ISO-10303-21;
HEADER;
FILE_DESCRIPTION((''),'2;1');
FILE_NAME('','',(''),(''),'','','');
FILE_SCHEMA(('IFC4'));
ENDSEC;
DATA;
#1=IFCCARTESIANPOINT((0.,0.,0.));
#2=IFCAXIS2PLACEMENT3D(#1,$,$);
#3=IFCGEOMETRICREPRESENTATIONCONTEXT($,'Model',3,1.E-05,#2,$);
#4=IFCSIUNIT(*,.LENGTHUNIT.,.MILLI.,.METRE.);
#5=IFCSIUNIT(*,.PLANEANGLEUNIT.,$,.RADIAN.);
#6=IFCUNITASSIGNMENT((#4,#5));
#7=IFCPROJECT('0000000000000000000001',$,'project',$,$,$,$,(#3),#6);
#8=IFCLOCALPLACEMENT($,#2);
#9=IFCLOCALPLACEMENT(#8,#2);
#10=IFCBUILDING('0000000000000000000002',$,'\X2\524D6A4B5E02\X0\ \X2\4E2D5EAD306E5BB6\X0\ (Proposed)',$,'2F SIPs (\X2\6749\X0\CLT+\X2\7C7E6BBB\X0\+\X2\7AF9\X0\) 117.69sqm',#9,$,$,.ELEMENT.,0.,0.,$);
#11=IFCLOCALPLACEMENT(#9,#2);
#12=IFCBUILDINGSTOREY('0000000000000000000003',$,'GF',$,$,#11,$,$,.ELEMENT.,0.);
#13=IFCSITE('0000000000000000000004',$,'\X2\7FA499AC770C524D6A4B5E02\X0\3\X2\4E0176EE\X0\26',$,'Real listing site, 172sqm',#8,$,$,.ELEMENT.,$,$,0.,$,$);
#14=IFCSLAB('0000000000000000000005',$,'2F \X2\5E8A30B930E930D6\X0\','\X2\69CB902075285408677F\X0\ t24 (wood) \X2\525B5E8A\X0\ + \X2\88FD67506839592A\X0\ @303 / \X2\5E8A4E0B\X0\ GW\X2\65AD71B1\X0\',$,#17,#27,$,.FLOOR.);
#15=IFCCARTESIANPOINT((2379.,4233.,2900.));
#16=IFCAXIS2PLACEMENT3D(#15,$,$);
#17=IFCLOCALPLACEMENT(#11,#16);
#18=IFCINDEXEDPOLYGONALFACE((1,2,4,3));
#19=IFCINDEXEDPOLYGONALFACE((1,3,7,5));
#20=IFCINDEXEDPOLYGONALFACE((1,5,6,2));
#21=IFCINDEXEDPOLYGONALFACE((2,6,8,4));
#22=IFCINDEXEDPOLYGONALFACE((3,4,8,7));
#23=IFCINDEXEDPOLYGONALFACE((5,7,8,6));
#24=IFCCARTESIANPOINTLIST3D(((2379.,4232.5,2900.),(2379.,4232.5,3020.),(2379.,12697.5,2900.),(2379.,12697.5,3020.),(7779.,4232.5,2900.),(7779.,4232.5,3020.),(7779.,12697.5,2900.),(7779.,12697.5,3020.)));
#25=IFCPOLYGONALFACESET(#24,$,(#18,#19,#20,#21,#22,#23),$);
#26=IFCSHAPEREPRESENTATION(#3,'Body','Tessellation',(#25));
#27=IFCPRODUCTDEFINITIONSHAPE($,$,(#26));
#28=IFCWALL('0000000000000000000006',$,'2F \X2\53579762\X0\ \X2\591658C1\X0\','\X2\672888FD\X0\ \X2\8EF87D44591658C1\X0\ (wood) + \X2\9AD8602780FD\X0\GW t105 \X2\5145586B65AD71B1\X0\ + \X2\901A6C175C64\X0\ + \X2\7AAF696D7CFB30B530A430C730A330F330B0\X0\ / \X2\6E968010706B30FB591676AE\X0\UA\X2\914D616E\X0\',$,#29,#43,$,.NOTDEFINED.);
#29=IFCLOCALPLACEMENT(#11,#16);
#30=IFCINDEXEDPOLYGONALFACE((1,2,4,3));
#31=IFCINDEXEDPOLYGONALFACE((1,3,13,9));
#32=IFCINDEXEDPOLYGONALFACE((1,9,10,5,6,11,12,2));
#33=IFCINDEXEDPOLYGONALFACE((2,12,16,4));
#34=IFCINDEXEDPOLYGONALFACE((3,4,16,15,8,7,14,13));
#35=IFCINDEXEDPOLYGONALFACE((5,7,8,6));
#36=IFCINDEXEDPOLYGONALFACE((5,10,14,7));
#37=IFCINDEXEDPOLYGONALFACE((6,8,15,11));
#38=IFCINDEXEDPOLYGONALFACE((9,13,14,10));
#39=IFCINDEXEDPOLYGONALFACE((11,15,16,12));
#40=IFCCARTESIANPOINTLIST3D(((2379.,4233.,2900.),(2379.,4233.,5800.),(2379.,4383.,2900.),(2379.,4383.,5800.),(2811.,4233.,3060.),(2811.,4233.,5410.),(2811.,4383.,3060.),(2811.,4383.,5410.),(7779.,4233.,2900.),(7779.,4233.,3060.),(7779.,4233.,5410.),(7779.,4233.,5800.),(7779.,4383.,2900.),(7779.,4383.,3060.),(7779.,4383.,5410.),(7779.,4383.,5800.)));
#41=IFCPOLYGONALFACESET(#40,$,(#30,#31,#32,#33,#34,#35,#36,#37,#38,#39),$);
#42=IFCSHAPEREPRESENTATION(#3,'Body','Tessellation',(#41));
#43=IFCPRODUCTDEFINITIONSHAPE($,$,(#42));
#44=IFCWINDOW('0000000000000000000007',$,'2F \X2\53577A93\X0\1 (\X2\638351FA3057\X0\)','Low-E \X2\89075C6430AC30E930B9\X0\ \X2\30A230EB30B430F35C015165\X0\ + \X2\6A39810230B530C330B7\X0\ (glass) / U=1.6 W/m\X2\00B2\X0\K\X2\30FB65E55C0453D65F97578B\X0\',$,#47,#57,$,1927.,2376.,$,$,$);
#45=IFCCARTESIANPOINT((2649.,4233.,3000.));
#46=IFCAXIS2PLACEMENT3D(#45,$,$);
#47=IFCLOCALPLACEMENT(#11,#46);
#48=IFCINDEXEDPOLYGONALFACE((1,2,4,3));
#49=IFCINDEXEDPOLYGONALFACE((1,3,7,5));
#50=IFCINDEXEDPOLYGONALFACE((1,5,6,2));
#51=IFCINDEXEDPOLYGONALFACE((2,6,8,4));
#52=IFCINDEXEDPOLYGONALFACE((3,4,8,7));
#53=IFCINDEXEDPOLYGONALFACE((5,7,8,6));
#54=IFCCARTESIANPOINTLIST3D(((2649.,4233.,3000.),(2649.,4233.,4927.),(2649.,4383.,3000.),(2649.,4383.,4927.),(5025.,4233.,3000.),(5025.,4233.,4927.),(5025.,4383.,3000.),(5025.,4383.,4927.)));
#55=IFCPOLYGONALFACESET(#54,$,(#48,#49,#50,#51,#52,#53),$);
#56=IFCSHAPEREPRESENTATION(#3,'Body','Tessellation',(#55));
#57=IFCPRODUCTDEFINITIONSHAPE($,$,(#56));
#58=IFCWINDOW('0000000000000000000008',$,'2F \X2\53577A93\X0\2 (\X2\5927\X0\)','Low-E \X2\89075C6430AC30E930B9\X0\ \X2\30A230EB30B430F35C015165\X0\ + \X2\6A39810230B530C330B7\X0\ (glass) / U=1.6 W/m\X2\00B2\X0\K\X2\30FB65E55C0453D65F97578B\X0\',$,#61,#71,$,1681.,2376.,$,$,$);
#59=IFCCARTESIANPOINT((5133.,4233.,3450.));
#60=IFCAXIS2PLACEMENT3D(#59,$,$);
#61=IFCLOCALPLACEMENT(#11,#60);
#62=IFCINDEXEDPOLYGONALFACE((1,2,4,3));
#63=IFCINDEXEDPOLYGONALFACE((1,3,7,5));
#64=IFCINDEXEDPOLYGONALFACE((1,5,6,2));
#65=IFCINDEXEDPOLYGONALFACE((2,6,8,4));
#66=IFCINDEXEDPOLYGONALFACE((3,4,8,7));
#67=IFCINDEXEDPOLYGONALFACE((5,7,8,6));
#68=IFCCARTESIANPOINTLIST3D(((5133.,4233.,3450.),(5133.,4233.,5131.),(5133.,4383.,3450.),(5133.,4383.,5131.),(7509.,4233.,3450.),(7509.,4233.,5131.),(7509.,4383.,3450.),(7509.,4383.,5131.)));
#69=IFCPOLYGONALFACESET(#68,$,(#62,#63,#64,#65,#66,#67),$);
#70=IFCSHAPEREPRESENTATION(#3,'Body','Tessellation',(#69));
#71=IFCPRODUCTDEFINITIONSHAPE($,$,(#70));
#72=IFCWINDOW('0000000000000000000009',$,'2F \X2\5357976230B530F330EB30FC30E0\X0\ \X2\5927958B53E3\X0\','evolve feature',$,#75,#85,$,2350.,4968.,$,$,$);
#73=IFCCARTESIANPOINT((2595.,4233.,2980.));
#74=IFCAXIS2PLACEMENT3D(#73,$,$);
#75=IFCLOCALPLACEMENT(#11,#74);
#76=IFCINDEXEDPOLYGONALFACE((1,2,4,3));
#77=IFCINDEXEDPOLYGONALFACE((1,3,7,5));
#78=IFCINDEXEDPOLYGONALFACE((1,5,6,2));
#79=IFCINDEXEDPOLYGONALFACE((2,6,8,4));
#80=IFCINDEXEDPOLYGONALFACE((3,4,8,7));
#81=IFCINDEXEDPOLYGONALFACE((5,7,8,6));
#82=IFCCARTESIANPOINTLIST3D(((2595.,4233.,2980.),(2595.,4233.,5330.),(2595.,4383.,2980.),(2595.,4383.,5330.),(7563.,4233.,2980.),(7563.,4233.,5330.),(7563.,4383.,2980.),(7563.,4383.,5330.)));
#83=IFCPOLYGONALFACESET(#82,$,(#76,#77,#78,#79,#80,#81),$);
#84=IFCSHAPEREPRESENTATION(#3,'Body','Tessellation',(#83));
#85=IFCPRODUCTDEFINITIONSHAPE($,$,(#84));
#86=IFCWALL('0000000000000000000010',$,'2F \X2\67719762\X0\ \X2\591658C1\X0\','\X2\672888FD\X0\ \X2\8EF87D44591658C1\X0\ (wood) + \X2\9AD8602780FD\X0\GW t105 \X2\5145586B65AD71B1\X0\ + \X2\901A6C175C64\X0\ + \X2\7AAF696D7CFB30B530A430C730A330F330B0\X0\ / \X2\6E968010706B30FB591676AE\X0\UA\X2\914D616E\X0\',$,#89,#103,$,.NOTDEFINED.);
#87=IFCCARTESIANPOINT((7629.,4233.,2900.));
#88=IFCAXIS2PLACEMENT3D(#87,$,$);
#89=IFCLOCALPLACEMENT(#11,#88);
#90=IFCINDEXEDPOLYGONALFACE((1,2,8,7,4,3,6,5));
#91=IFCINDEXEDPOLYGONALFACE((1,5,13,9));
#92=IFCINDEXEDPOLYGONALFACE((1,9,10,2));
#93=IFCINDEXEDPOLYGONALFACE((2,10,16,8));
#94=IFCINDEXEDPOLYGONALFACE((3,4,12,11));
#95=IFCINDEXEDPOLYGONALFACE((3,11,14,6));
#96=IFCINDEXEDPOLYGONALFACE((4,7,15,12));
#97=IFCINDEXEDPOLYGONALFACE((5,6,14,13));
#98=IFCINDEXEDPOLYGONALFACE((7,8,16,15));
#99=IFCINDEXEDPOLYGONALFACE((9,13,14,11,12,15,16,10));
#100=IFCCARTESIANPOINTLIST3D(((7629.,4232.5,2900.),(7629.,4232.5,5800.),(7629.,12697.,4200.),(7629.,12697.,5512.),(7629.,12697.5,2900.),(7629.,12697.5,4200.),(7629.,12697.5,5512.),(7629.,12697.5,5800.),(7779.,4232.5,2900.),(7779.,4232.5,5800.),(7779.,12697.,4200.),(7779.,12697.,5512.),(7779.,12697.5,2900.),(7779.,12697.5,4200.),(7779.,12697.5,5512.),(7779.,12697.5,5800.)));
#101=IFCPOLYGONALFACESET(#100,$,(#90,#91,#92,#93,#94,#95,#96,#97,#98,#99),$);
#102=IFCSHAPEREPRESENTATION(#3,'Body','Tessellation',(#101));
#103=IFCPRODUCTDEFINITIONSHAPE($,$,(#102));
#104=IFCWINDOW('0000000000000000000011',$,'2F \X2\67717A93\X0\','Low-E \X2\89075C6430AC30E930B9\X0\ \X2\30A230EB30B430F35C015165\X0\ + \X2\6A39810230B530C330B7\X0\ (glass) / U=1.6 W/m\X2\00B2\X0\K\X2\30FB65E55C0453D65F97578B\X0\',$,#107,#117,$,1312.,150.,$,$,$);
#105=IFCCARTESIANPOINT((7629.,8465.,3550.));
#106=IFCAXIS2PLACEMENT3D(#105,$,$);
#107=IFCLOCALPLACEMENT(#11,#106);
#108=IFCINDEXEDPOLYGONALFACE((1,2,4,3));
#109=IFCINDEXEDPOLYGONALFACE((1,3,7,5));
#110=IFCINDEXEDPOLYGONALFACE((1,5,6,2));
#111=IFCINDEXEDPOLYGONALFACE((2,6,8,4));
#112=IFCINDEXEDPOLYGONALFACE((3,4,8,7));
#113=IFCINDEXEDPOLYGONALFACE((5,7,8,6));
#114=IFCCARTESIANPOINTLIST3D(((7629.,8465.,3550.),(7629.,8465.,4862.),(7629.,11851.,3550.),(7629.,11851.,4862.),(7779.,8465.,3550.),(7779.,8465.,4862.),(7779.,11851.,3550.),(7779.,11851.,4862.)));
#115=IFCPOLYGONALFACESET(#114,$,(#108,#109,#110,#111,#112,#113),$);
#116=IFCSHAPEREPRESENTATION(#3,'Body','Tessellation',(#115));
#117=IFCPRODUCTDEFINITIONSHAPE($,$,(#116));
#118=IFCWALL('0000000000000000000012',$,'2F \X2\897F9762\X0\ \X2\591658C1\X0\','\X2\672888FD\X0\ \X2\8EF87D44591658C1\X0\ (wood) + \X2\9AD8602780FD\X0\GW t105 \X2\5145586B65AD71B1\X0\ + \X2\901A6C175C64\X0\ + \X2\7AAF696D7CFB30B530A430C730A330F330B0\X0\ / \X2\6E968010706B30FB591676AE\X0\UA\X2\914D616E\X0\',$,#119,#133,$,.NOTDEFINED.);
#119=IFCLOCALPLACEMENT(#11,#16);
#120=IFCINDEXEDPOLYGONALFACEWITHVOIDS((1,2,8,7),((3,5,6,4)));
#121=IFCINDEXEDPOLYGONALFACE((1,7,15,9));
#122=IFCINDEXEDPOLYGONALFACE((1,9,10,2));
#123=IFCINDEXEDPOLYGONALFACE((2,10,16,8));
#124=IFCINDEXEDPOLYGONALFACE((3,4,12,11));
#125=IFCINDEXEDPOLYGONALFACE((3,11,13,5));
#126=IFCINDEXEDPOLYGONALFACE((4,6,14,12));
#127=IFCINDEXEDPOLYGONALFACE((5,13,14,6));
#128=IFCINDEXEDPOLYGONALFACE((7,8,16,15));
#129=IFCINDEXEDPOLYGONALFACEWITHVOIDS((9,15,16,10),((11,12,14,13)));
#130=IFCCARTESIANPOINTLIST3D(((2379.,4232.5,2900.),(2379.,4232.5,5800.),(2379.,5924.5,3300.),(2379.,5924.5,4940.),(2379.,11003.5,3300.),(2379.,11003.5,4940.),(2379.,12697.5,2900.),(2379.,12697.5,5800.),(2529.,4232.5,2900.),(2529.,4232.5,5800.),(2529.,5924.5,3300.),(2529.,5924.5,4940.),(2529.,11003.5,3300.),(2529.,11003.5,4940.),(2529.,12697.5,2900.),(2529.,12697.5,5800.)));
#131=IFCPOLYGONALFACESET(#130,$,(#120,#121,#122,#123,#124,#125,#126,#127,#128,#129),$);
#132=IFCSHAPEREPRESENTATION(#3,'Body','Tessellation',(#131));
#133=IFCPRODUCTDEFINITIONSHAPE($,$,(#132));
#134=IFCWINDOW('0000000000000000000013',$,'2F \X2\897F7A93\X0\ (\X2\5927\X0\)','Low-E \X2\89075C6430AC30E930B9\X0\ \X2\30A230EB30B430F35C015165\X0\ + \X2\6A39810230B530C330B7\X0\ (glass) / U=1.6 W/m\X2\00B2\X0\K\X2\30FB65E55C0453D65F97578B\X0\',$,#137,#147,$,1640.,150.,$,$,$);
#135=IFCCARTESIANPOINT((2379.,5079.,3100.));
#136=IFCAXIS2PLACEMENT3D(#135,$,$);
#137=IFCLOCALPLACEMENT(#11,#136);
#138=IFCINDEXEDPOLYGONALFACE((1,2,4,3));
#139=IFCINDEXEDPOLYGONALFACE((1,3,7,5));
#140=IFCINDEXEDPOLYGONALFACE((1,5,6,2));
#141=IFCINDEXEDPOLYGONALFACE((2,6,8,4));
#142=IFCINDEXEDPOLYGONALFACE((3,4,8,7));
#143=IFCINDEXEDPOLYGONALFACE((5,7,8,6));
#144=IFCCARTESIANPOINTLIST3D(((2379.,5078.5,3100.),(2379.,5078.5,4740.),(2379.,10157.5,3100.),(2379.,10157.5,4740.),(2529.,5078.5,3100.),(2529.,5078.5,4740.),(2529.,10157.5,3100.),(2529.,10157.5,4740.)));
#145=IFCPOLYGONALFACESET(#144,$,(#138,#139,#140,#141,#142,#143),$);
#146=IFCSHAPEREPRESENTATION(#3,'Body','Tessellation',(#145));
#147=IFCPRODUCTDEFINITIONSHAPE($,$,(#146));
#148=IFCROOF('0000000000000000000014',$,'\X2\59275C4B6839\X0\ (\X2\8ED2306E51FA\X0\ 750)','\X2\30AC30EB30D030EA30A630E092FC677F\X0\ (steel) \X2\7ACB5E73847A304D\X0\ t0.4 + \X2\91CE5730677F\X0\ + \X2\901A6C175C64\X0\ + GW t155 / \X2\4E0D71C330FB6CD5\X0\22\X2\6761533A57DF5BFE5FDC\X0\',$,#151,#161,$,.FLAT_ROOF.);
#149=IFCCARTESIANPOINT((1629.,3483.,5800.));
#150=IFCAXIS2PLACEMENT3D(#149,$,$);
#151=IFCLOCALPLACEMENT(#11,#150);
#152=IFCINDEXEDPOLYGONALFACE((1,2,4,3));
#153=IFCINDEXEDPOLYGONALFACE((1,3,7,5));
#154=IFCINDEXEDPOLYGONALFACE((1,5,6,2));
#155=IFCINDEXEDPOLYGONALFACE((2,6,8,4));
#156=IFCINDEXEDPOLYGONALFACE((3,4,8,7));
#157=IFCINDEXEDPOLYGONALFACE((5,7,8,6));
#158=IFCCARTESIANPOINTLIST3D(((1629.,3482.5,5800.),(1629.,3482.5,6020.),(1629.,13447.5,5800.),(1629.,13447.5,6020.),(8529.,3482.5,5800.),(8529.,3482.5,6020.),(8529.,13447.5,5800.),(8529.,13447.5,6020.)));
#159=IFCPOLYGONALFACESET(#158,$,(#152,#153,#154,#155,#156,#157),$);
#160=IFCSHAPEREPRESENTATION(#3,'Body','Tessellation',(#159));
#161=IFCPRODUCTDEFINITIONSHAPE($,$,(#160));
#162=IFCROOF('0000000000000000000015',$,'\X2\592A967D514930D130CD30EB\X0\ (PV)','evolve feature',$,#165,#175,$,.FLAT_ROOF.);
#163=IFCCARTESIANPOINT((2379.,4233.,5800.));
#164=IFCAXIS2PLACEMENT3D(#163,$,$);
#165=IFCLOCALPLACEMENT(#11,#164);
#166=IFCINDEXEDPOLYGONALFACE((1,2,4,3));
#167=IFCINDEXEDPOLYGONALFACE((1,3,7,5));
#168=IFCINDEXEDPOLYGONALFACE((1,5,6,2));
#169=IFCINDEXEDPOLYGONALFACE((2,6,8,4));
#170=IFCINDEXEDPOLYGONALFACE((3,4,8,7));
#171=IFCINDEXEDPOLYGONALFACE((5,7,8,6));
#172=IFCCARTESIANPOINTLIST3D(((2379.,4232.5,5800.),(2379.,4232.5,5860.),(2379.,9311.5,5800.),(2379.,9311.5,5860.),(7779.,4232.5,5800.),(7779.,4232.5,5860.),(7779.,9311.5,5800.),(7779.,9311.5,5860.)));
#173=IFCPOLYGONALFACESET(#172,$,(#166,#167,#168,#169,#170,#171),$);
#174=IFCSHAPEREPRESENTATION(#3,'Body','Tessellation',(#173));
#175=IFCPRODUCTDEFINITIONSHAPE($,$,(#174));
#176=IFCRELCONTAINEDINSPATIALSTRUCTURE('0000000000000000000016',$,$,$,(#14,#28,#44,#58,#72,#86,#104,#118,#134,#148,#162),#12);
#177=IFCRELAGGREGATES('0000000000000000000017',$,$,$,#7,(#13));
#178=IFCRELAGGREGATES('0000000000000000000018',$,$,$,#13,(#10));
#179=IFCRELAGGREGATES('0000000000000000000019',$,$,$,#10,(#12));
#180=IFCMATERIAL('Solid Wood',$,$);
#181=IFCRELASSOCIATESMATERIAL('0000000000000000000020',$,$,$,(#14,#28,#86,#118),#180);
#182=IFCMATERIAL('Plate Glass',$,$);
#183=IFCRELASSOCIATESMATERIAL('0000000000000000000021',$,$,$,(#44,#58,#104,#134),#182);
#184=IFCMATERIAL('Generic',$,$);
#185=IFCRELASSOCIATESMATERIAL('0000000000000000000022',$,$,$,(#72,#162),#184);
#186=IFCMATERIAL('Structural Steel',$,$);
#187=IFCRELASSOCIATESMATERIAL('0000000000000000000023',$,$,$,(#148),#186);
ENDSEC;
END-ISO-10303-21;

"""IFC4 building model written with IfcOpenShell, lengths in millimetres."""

from ifc_helpers import new_model, si_unit, frame, frame_2d, origin, place, context, project, spatial, rectangle, extrude, material, element, fill, save


model = new_model("IFC4")

# Units and contexts
model_context = context("Model", 3, precision=1e-05, world=origin())
ifc_project = project(units=[si_unit("LENGTHUNIT", "METRE", prefix="MILLI"), si_unit("PLANEANGLEUNIT", "RADIAN")], contexts=[model_context])

# Site, building, storey
site_placement = place(None, origin())
site = spatial("IfcSite", under=ifc_project, at=site_placement, Name="群馬県前橋市3丁目26", ObjectType="Real listing site, 172sqm", CompositionType="ELEMENT", RefElevation=0.0)
building_placement = place(site_placement, origin())
building = spatial("IfcBuilding", under=site, at=building_placement, Name="前橋市 中庭の家 (Proposed)", ObjectType="2F SIPs (杉CLT+籾殻+竹) 117.69sqm", CompositionType="ELEMENT", ElevationOfRefHeight=0.0, ElevationOfTerrain=0.0)
storey_placement = place(building_placement, origin())
storey = spatial("IfcBuildingStorey", under=building, at=storey_placement, Name="GF", CompositionType="ELEMENT", Elevation=0.0)

# Slab
ifc_material_1 = material(Name="Solid Wood")
slab_placement = place(storey_placement, frame((2379.0, 4233.0, 2900.0)))
element("IfcSlab", 1, at=slab_placement, inside=storey, material=ifc_material_1, Name="2F 床スラブ", Description="構造用合板 t24 (wood) 剛床 + 製材根太 @303 / 床下 GW断熱", PredefinedType="FLOOR", context=model_context, shape_type="SweptSolid", body=[
    extrude(rectangle(XDim=5400.0, YDim=8465.0, at=frame_2d((2700.0, 4232.0))), frame((2379.0, 4233.0, 2900.0)), (0.0, 0.0, 1.0), 120.0),
])

# Wall, openings, windows
wall_1_placement = place(storey_placement, frame((2379.0, 4233.0, 2900.0)))
wall_1 = element("IfcWall", 2, at=wall_1_placement, inside=storey, material=ifc_material_1, Name="2F 南面 外壁", Description="木製 軸組外壁 (wood) + 高性能GW t105 充填断熱 + 通気層 + 窯業系サイディング / 準耐火・外皮UA配慮", PredefinedType="NOTDEFINED", context=model_context, shape_type="SweptSolid", body=[
    extrude(rectangle(XDim=5400.0, YDim=150.0, at=frame_2d((2700.0, 75.0))), frame((2379.0, 4233.0, 2900.0)), (0.0, 0.0, 1.0), 2900.0),
])
opening_1_placement = place(storey_placement, frame((2649.0, 4233.0, 3000.0)))
opening_1 = element("IfcOpeningElement", 3, at=opening_1_placement, cuts=wall_1, PredefinedType="NOTDEFINED", context=model_context, shape_type="SweptSolid", body=[
    extrude(rectangle(XDim=2376.0, YDim=150.0, at=frame_2d((1188.0, 75.0))), frame((2649.0, 4233.0, 3000.0)), (0.0, 0.0, 1.0), 1927.0),
])
opening_2_placement = place(storey_placement, frame((5133.0, 4233.0, 3450.0)))
opening_2 = element("IfcOpeningElement", 4, at=opening_2_placement, cuts=wall_1, PredefinedType="NOTDEFINED", context=model_context, shape_type="SweptSolid", body=[
    extrude(rectangle(XDim=2376.0, YDim=150.0, at=frame_2d((1188.0, 75.0))), frame((5133.0, 4233.0, 3450.0)), (0.0, 0.0, 1.0), 1681.0),
])
opening_3_placement = place(storey_placement, frame((2595.0, 4233.0, 2980.0)))
opening_3 = element("IfcOpeningElement", 5, at=opening_3_placement, cuts=wall_1, PredefinedType="NOTDEFINED", context=model_context, shape_type="SweptSolid", body=[
    extrude(rectangle(XDim=4968.0, YDim=150.0, at=frame_2d((2484.0, 75.0))), frame((2595.0, 4233.0, 2980.0)), (0.0, 0.0, 1.0), 2350.0),
])
ifc_material_2 = material(Name="Plate Glass")
window_1_placement = place(storey_placement, frame((2649.0, 4233.0, 3000.0)))
window_1 = element("IfcWindow", 6, at=window_1_placement, inside=storey, material=ifc_material_2, Name="2F 南窓1 (掃出し)", Description="Low-E 複層ガラス アルゴン封入 + 樹脂サッシ (glass) / U=1.6 W/m²K・日射取得型", OverallHeight=1927.0, OverallWidth=2376.0, context=model_context, shape_type="SweptSolid", body=[
    extrude(rectangle(XDim=2376.0, YDim=150.0, at=frame_2d((1188.0, 75.0))), frame((2649.0, 4233.0, 3000.0)), (0.0, 0.0, 1.0), 1927.0),
])
fill(opening_1, window_1)
window_2_placement = place(storey_placement, frame((5133.0, 4233.0, 3450.0)))
window_2 = element("IfcWindow", 7, at=window_2_placement, inside=storey, material=ifc_material_2, Name="2F 南窓2 (大)", Description="Low-E 複層ガラス アルゴン封入 + 樹脂サッシ (glass) / U=1.6 W/m²K・日射取得型", OverallHeight=1681.0, OverallWidth=2376.0, context=model_context, shape_type="SweptSolid", body=[
    extrude(rectangle(XDim=2376.0, YDim=150.0, at=frame_2d((1188.0, 75.0))), frame((5133.0, 4233.0, 3450.0)), (0.0, 0.0, 1.0), 1681.0),
])
fill(opening_2, window_2)
ifc_material_3 = material(Name="Generic")
window_3_placement = place(storey_placement, frame((2595.0, 4233.0, 2980.0)))
window_3 = element("IfcWindow", 8, at=window_3_placement, inside=storey, material=ifc_material_3, Name="2F 南面サンルーム 大開口", Description="evolve feature", OverallHeight=2350.0, OverallWidth=4968.0, context=model_context, shape_type="SweptSolid", body=[
    extrude(rectangle(XDim=4968.0, YDim=150.0, at=frame_2d((2484.0, 75.0))), frame((2595.0, 4233.0, 2980.0)), (0.0, 0.0, 1.0), 2350.0),
])
fill(opening_3, window_3)

# Walls, openings, windows
wall_2_placement = place(storey_placement, frame((7629.0, 4233.0, 2900.0)))
wall_2 = element("IfcWall", 9, at=wall_2_placement, inside=storey, material=ifc_material_1, Name="2F 東面 外壁", Description="木製 軸組外壁 (wood) + 高性能GW t105 充填断熱 + 通気層 + 窯業系サイディング / 準耐火・外皮UA配慮", PredefinedType="NOTDEFINED", context=model_context, shape_type="SweptSolid", body=[
    extrude(rectangle(XDim=150.0, YDim=8465.0, at=frame_2d((75.0, 4232.0))), frame((7629.0, 4233.0, 2900.0)), (0.0, 0.0, 1.0), 2900.0),
])
opening_4_placement = place(storey_placement, frame((7629.0, 8465.0, 3550.0)))
opening_4 = element("IfcOpeningElement", 10, at=opening_4_placement, cuts=wall_2, PredefinedType="NOTDEFINED", context=model_context, shape_type="SweptSolid", body=[
    extrude(rectangle(XDim=150.0, YDim=3386.0, at=frame_2d((75.0, 1693.0))), frame((7629.0, 8465.0, 3550.0)), (0.0, 0.0, 1.0), 1312.0),
])
window_4_placement = place(storey_placement, frame((7629.0, 8465.0, 3550.0)))
window_4 = element("IfcWindow", 11, at=window_4_placement, inside=storey, material=ifc_material_2, Name="2F 東窓", Description="Low-E 複層ガラス アルゴン封入 + 樹脂サッシ (glass) / U=1.6 W/m²K・日射取得型", OverallHeight=1312.0, OverallWidth=150.0, context=model_context, shape_type="SweptSolid", body=[
    extrude(rectangle(XDim=150.0, YDim=3386.0, at=frame_2d((75.0, 1693.0))), frame((7629.0, 8465.0, 3550.0)), (0.0, 0.0, 1.0), 1312.0),
])
fill(opening_4, window_4)
wall_3_placement = place(storey_placement, frame((2379.0, 4233.0, 2900.0)))
wall_3 = element("IfcWall", 12, at=wall_3_placement, inside=storey, material=ifc_material_1, Name="2F 西面 外壁", Description="木製 軸組外壁 (wood) + 高性能GW t105 充填断熱 + 通気層 + 窯業系サイディング / 準耐火・外皮UA配慮", PredefinedType="NOTDEFINED", context=model_context, shape_type="SweptSolid", body=[
    extrude(rectangle(XDim=150.0, YDim=8465.0, at=frame_2d((75.0, 4232.0))), frame((2379.0, 4233.0, 2900.0)), (0.0, 0.0, 1.0), 2900.0),
])
opening_5_placement = place(storey_placement, frame((2379.0, 5079.0, 3100.0)))
opening_5 = element("IfcOpeningElement", 13, at=opening_5_placement, cuts=wall_3, PredefinedType="NOTDEFINED", context=model_context, shape_type="SweptSolid", body=[
    extrude(rectangle(XDim=150.0, YDim=5079.0, at=frame_2d((75.0, 2539.0))), frame((2379.0, 5079.0, 3100.0)), (0.0, 0.0, 1.0), 1640.0),
])
window_5_placement = place(storey_placement, frame((2379.0, 5079.0, 3100.0)))
window_5 = element("IfcWindow", 14, at=window_5_placement, inside=storey, material=ifc_material_2, Name="2F 西窓 (大)", Description="Low-E 複層ガラス アルゴン封入 + 樹脂サッシ (glass) / U=1.6 W/m²K・日射取得型", OverallHeight=1640.0, OverallWidth=150.0, context=model_context, shape_type="SweptSolid", body=[
    extrude(rectangle(XDim=150.0, YDim=5079.0, at=frame_2d((75.0, 2539.0))), frame((2379.0, 5079.0, 3100.0)), (0.0, 0.0, 1.0), 1640.0),
])
fill(opening_5, window_5)

# Roofs
ifc_material_4 = material(Name="Structural Steel")
roof_1_placement = place(storey_placement, frame((1629.0, 3483.0, 5800.0)))
element("IfcRoof", 15, at=roof_1_placement, inside=storey, material=ifc_material_4, Name="大屋根 (軒の出 750)", Description="ガルバリウム鋼板 (steel) 立平葺き t0.4 + 野地板 + 通気層 + GW t155 / 不燃・法22条区域対応", PredefinedType="FLAT_ROOF", context=model_context, shape_type="SweptSolid", body=[
    extrude(rectangle(XDim=6900.0, YDim=9965.0, at=frame_2d((3450.0, 4982.0))), frame((1629.0, 3483.0, 5800.0)), (0.0, 0.0, 1.0), 220.0),
])
roof_2_placement = place(storey_placement, frame((2379.0, 4233.0, 5800.0)))
element("IfcRoof", 16, at=roof_2_placement, inside=storey, material=ifc_material_3, Name="太陽光パネル (PV)", Description="evolve feature", PredefinedType="FLAT_ROOF", context=model_context, shape_type="SweptSolid", body=[
    extrude(rectangle(XDim=5400.0, YDim=5079.0, at=frame_2d((2700.0, 2539.0))), frame((2379.0, 4233.0, 5800.0)), (0.0, 0.0, 1.0), 60.0),
])

save(model, "model.ifc")
